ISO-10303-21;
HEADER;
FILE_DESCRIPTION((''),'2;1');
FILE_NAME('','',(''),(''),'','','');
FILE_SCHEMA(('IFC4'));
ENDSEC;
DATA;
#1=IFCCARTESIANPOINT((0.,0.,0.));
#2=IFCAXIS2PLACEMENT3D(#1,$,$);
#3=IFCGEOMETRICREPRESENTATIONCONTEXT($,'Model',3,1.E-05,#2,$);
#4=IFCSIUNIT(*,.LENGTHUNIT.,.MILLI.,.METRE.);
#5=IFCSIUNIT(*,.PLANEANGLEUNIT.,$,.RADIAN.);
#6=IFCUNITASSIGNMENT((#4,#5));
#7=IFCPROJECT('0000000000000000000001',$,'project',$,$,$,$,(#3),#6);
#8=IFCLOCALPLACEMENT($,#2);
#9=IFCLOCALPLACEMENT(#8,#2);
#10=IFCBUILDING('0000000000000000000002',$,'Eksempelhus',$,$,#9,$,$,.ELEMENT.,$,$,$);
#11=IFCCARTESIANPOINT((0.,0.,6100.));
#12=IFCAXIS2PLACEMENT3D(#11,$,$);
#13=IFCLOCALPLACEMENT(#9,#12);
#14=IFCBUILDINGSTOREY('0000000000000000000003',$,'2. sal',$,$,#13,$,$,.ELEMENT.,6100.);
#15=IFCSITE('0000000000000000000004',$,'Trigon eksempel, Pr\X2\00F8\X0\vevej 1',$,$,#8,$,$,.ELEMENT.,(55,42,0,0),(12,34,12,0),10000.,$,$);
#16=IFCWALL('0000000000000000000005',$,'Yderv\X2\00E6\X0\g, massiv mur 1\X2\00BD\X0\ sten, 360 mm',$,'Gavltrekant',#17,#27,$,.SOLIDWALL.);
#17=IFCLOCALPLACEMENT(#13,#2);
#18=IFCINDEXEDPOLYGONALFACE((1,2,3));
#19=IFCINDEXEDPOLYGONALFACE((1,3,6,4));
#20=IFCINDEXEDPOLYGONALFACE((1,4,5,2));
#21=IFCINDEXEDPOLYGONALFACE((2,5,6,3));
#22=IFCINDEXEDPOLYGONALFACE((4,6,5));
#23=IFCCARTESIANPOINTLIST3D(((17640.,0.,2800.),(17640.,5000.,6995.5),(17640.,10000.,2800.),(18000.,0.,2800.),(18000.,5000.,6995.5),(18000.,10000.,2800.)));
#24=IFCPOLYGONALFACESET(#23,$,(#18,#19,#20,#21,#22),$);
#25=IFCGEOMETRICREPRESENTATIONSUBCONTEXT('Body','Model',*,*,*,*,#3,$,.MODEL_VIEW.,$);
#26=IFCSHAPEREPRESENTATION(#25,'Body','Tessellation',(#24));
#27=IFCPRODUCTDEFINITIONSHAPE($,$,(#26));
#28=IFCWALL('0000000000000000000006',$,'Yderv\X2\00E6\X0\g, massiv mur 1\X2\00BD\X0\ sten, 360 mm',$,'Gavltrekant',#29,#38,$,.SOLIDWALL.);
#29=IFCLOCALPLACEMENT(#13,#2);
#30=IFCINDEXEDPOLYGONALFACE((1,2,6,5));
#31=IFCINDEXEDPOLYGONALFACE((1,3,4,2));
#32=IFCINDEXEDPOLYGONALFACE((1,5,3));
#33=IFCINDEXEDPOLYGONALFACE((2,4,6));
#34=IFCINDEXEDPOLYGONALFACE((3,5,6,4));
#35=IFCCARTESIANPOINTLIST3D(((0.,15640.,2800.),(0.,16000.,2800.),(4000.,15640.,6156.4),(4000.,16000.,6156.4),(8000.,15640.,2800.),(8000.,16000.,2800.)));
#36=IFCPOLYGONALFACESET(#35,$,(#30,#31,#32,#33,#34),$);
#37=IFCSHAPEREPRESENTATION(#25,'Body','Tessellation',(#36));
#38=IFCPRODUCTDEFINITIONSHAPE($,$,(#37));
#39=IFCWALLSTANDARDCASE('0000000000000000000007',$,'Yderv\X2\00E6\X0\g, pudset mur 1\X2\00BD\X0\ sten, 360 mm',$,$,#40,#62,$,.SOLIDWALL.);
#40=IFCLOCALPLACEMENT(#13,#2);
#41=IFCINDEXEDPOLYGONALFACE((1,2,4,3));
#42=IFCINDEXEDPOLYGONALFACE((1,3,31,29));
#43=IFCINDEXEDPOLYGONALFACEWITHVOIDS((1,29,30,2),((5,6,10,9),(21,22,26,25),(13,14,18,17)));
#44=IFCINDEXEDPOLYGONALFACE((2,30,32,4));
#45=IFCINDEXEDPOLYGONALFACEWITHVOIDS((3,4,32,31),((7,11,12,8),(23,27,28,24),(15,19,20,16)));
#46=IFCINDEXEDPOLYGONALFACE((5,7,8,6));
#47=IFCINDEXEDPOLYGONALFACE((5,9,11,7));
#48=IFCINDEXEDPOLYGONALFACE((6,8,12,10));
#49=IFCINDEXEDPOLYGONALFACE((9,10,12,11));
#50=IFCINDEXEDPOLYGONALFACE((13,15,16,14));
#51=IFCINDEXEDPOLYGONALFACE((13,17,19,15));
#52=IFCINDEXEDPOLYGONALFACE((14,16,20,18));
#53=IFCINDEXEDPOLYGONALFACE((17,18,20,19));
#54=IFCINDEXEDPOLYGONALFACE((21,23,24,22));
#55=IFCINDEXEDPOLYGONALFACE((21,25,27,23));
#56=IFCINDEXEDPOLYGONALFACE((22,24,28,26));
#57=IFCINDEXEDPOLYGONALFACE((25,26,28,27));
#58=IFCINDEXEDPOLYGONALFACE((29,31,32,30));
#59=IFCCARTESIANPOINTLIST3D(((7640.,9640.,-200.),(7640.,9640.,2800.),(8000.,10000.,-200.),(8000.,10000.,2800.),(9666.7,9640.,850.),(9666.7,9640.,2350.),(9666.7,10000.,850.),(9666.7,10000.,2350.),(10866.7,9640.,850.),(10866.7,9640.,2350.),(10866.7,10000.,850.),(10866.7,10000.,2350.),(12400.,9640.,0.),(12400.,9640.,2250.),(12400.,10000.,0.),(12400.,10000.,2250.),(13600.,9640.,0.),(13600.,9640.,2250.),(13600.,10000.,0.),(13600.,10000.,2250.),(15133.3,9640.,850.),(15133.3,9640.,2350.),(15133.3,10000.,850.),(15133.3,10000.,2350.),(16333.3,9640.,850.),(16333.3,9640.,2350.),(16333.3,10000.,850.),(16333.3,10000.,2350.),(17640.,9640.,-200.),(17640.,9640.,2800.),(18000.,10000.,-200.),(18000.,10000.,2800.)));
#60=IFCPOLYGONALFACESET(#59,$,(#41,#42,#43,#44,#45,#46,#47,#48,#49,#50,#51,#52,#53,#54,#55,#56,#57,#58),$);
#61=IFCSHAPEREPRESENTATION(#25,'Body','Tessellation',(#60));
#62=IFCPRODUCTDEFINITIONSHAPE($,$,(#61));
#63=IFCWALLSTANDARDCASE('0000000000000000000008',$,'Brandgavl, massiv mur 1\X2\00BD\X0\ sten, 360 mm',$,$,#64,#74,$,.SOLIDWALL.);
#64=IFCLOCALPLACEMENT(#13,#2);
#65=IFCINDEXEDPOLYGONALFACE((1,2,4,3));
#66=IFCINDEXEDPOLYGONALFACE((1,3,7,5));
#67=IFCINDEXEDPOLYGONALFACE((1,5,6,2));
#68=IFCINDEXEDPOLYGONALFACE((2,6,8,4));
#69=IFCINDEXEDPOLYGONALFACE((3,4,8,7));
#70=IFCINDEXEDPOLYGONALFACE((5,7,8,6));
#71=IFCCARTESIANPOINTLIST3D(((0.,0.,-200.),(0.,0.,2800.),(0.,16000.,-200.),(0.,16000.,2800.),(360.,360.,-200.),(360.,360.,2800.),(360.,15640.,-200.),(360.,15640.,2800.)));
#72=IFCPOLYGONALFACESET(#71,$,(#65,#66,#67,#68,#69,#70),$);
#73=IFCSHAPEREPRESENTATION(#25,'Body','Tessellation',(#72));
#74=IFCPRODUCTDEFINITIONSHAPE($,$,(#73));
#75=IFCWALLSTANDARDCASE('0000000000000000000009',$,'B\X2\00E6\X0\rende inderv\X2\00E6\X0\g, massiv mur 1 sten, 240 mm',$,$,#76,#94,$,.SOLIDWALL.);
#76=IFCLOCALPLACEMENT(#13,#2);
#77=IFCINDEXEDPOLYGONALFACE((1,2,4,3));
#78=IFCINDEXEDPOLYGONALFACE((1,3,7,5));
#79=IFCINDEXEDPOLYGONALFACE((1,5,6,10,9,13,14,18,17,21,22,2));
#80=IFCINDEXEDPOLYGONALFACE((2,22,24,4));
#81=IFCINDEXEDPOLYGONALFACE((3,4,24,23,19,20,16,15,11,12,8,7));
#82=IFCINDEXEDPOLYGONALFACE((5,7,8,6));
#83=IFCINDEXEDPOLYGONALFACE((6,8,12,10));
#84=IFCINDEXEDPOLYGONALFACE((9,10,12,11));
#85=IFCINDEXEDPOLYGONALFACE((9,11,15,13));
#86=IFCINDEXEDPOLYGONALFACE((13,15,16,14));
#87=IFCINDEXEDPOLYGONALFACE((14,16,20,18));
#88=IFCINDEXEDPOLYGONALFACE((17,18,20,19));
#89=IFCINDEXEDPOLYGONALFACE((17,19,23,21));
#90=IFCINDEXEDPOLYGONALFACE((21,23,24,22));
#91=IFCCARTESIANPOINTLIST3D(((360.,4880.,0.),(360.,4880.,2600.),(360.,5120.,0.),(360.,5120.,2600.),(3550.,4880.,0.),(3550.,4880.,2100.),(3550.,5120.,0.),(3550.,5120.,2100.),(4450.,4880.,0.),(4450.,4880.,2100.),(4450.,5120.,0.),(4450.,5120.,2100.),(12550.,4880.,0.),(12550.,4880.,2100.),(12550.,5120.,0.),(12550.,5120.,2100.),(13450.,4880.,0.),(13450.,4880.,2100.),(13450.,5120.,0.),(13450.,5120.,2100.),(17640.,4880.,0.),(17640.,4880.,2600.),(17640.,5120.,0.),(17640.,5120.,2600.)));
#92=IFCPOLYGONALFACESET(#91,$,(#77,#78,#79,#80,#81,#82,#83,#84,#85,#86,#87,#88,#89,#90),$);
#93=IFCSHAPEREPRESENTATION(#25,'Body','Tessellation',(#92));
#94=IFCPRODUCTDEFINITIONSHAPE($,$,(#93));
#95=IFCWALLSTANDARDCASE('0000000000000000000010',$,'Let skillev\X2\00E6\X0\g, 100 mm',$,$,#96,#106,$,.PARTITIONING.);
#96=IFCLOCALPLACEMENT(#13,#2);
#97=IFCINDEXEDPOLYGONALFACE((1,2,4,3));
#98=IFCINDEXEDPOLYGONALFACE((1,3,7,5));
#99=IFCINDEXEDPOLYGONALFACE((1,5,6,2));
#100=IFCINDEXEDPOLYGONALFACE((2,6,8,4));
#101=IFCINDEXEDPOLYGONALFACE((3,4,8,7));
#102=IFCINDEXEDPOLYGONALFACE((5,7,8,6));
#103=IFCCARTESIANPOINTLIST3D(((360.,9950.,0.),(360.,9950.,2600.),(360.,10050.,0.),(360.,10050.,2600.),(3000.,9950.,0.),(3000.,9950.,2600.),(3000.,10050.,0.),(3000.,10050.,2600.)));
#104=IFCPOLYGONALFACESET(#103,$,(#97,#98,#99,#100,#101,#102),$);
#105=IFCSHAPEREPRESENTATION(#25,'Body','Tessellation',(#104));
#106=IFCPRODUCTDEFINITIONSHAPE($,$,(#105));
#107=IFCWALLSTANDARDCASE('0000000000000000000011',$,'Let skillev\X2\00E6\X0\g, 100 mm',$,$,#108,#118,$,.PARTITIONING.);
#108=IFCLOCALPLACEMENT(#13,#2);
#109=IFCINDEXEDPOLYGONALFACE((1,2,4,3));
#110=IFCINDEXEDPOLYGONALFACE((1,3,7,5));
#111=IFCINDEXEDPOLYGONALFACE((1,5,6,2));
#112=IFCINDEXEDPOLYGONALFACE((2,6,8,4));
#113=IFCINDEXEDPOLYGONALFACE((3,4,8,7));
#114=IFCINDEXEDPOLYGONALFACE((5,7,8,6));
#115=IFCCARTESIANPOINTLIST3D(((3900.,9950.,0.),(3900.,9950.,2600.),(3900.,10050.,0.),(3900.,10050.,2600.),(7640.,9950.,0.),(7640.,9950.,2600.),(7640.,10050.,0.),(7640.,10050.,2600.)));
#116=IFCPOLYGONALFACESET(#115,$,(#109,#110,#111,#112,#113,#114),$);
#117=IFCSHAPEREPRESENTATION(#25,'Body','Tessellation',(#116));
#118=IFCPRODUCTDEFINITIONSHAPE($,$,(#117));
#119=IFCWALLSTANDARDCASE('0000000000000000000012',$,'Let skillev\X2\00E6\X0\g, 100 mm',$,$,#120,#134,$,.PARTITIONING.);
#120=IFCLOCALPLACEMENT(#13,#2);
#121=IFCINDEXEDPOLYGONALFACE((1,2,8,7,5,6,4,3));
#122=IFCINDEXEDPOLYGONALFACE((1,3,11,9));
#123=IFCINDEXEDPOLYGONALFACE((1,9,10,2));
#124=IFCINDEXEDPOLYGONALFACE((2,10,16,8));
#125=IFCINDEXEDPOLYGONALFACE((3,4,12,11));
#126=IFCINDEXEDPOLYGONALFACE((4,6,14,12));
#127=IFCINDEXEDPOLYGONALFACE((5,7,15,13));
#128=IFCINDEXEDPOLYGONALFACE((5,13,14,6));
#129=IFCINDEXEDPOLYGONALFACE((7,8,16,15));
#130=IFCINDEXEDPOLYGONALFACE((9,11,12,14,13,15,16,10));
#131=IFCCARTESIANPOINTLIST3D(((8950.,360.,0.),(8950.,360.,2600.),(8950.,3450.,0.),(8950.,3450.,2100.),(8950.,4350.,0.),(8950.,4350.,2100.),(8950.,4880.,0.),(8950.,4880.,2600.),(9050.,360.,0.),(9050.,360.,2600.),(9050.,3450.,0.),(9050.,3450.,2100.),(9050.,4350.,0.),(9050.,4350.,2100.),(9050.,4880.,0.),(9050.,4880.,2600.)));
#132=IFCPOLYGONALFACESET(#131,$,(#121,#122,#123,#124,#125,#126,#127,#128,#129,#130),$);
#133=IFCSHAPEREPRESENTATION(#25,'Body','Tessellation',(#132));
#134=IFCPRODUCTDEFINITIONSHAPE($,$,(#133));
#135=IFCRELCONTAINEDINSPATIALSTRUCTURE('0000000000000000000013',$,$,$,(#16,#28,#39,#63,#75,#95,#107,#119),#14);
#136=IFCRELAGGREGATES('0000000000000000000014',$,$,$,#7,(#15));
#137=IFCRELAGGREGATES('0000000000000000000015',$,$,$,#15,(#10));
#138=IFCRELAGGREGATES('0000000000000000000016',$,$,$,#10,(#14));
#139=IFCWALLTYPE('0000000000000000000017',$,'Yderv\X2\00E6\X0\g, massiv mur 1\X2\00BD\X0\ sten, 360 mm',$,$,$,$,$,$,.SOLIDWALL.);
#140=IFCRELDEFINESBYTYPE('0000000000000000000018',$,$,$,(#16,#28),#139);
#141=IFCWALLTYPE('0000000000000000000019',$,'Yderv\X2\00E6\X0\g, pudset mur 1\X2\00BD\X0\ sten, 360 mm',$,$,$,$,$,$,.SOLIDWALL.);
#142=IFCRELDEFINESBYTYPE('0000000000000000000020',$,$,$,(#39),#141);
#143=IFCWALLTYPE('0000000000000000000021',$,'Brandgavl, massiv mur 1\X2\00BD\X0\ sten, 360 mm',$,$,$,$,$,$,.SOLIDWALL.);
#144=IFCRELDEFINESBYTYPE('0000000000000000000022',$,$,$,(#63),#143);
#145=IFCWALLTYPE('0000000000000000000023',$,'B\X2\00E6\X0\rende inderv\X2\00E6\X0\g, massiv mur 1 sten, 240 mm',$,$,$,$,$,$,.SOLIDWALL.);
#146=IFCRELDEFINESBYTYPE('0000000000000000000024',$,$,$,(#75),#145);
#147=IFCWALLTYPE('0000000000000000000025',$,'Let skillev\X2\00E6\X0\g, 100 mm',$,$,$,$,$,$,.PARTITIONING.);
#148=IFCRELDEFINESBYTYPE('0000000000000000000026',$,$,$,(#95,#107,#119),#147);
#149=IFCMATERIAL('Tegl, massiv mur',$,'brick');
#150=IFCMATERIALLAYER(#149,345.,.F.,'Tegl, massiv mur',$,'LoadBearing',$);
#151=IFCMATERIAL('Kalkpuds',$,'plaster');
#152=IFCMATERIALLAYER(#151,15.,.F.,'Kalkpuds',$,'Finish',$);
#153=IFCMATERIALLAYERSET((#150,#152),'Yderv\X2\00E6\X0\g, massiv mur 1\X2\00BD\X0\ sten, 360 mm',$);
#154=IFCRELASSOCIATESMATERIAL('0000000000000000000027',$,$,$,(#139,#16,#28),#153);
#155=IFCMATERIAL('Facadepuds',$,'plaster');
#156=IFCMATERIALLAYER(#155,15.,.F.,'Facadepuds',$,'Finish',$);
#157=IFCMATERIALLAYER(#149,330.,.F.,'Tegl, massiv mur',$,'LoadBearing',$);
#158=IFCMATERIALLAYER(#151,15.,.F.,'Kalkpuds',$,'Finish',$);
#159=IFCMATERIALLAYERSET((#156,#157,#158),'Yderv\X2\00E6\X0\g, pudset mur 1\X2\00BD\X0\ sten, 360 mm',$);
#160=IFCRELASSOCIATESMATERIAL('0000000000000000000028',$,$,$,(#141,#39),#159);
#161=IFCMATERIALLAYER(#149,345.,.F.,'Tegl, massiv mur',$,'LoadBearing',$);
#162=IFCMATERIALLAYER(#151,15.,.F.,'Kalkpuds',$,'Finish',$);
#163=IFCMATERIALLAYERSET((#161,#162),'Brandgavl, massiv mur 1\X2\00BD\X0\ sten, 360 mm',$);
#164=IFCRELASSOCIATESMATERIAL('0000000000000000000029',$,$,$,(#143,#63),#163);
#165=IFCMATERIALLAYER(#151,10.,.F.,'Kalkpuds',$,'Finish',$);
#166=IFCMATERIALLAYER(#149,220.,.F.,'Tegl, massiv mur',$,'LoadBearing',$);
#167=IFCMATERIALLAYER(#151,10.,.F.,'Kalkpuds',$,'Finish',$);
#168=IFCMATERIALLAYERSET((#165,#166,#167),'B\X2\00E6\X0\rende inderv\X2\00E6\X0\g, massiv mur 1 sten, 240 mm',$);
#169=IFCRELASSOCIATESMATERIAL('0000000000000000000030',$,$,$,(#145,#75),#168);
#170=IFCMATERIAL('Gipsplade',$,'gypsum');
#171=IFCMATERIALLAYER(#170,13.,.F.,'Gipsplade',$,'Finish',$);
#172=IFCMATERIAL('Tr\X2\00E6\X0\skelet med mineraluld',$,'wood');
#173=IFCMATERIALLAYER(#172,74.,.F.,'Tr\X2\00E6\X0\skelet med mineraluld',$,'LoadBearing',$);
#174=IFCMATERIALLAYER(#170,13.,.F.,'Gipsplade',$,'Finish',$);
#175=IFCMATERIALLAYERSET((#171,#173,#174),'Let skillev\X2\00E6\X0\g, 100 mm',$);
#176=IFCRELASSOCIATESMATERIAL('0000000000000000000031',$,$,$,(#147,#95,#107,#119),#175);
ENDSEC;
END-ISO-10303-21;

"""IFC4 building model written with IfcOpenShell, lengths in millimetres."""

from ifc_helpers import new_model, si_unit, frame, origin, place, context, subcontext, project, spatial, polyline, rectangle, outline, extrude, material, layer, layer_set, layer_usage, type_object, element, save


model = new_model("IFC4")

# Units and contexts
model_context = context("Model", 3, precision=1e-05, world=origin())
body_context = subcontext(model_context, "Body", "Model", "MODEL_VIEW")
ifc_project = project(units=[si_unit("LENGTHUNIT", "METRE", prefix="MILLI"), si_unit("PLANEANGLEUNIT", "RADIAN")], contexts=[model_context])

# Site, building, storey
site_placement = place(None, origin())
site = spatial("IfcSite", under=ifc_project, at=site_placement, Name="Trigon eksempel, Prøvevej 1", CompositionType="ELEMENT", RefLatitude=(55, 42, 0, 0), RefLongitude=(12, 34, 12, 0), RefElevation=10000.0)
building_placement = place(site_placement, origin())
building = spatial("IfcBuilding", under=site, at=building_placement, Name="Eksempelhus", CompositionType="ELEMENT")
storey_placement = place(building_placement, frame((0.0, 0.0, 6100.0)))
storey = spatial("IfcBuildingStorey", under=building, at=storey_placement, Name="2. sal", CompositionType="ELEMENT", Elevation=6100.0)

# Shared definitions
ifc_material_1 = material(Name="Tegl, massiv mur", Category="brick")
ifc_layer_1 = layer(ifc_material_1, 345.0, ventilated=False, Name="Tegl, massiv mur", Category="LoadBearing")
ifc_material_2 = material(Name="Kalkpuds", Category="plaster")
ifc_layer_2 = layer(ifc_material_2, 15.0, ventilated=False, Name="Kalkpuds", Category="Finish")
ifc_layer_set_1 = layer_set([ifc_layer_1, ifc_layer_2], Name="Ydervæg, massiv mur 1½ sten, 360 mm")
wall_type_1 = type_object("IfcWallType", Name="Ydervæg, massiv mur 1½ sten, 360 mm", PredefinedType="SOLIDWALL", material=ifc_layer_set_1)

# Walls
wall_1_placement = place(storey_placement, frame((18000.0, 0.0, 2800.0), z_axis=(0.0, 0.0, 1.0), x_axis=(0.0, 1.0, 0.0)))
element("IfcWall", 1, at=wall_1_placement, inside=storey, type_object=wall_type_1, material=ifc_layer_set_1, Name="Ydervæg, massiv mur 1½ sten, 360 mm", ObjectType="Gavltrekant", PredefinedType="SOLIDWALL", context=body_context, shape_type="SweptSolid", body=[
    extrude(outline(polyline([(10000.0, 0.0), (0.0, 0.0), (5000.0, -4195.5), (10000.0, 0.0)])), frame((0.0, 0.0, 0.0), z_axis=(0.0, 1.0, 0.0), x_axis=(1.0, 0.0, 0.0)), (0.0, 0.0, 1.0), 360.0),
])
wall_2_placement = place(storey_placement, frame((8000.0, 16000.0, 2800.0), z_axis=(0.0, 0.0, 1.0), x_axis=(-1.0, 0.0, 0.0)))
element("IfcWall", 2, at=wall_2_placement, inside=storey, type_object=wall_type_1, material=ifc_layer_set_1, Name="Ydervæg, massiv mur 1½ sten, 360 mm", ObjectType="Gavltrekant", PredefinedType="SOLIDWALL", context=body_context, shape_type="SweptSolid", body=[
    extrude(outline(polyline([(8000.0, 0.0), (0.0, 0.0), (4000.0, -3356.4), (8000.0, 0.0)])), frame((0.0, 0.0, 0.0), z_axis=(0.0, 1.0, 0.0), x_axis=(1.0, 0.0, 0.0)), (0.0, 0.0, 1.0), 360.0),
])

# Wall, openings
ifc_material_3 = material(Name="Facadepuds", Category="plaster")
ifc_layer_3 = layer(ifc_material_3, 15.0, ventilated=False, Name="Facadepuds", Category="Finish")
ifc_layer_4 = layer(ifc_material_1, 330.0, ventilated=False, Name="Tegl, massiv mur", Category="LoadBearing")
ifc_layer_5 = layer(ifc_material_2, 15.0, ventilated=False, Name="Kalkpuds", Category="Finish")
ifc_layer_set_2 = layer_set([ifc_layer_3, ifc_layer_4, ifc_layer_5], Name="Ydervæg, pudset mur 1½ sten, 360 mm")
ifc_layer_usage_1 = layer_usage(ifc_layer_set_2, "AXIS2", "POSITIVE", 0.0)
wall_type_2 = type_object("IfcWallType", Name="Ydervæg, pudset mur 1½ sten, 360 mm", PredefinedType="SOLIDWALL", material=ifc_layer_set_2)
wall_3_placement = place(storey_placement, frame((18000.0, 10000.0, -200.0), z_axis=(0.0, 0.0, 1.0), x_axis=(-1.0, 0.0, 0.0)))
wall_3 = element("IfcWallStandardCase", 3, at=wall_3_placement, inside=storey, type_object=wall_type_2, material=ifc_layer_usage_1, Name="Ydervæg, pudset mur 1½ sten, 360 mm", PredefinedType="SOLIDWALL", context=body_context, shape_type="SweptSolid", body=[
    extrude(outline(polyline([(0.0, 0.0), (10000.0, 0.0), (10360.0, 360.0), (360.0, 360.0), (0.0, 0.0)])), origin(), (0.0, 0.0, 1.0), 3000.0),
])
opening_1_placement = place(wall_3_placement, frame((1666.7, 0.0, 1050.0)))
element("IfcOpeningElement", 4, at=opening_1_placement, cuts=wall_3, PredefinedType="OPENING", context=body_context, shape_type="SweptSolid", body=[
    extrude(rectangle(XDim=1200.0, YDim=1500.0), frame((600.0, 0.0, 750.0), z_axis=(0.0, 1.0, 0.0), x_axis=(1.0, 0.0, 0.0)), (0.0, 0.0, 1.0), 360.0),
])
opening_2_placement = place(wall_3_placement, frame((4400.0, 0.0, 200.0)))
element("IfcOpeningElement", 5, at=opening_2_placement, cuts=wall_3, PredefinedType="OPENING", context=body_context, shape_type="SweptSolid", body=[
    extrude(rectangle(XDim=1200.0, YDim=2250.0), frame((600.0, 0.0, 1125.0), z_axis=(0.0, 1.0, 0.0), x_axis=(1.0, 0.0, 0.0)), (0.0, 0.0, 1.0), 360.0),
])
opening_3_placement = place(wall_3_placement, frame((7133.3, 0.0, 1050.0)))
element("IfcOpeningElement", 6, at=opening_3_placement, cuts=wall_3, PredefinedType="OPENING", context=body_context, shape_type="SweptSolid", body=[
    extrude(rectangle(XDim=1200.0, YDim=1500.0), frame((600.0, 0.0, 750.0), z_axis=(0.0, 1.0, 0.0), x_axis=(1.0, 0.0, 0.0)), (0.0, 0.0, 1.0), 360.0),
])

# Wall
ifc_layer_6 = layer(ifc_material_1, 345.0, ventilated=False, Name="Tegl, massiv mur", Category="LoadBearing")
ifc_layer_7 = layer(ifc_material_2, 15.0, ventilated=False, Name="Kalkpuds", Category="Finish")
ifc_layer_set_3 = layer_set([ifc_layer_6, ifc_layer_7], Name="Brandgavl, massiv mur 1½ sten, 360 mm")
ifc_layer_usage_2 = layer_usage(ifc_layer_set_3, "AXIS2", "POSITIVE", 0.0)
wall_type_3 = type_object("IfcWallType", Name="Brandgavl, massiv mur 1½ sten, 360 mm", PredefinedType="SOLIDWALL", material=ifc_layer_set_3)
wall_4_placement = place(storey_placement, frame((0.0, 16000.0, -200.0), z_axis=(0.0, 0.0, 1.0), x_axis=(0.0, -1.0, 0.0)))
element("IfcWallStandardCase", 7, at=wall_4_placement, inside=storey, type_object=wall_type_3, material=ifc_layer_usage_2, Name="Brandgavl, massiv mur 1½ sten, 360 mm", PredefinedType="SOLIDWALL", context=body_context, shape_type="SweptSolid", body=[
    extrude(outline(polyline([(0.0, 0.0), (16000.0, 0.0), (15640.0, 360.0), (360.0, 360.0), (0.0, 0.0)])), origin(), (0.0, 0.0, 1.0), 3000.0),
])

# Wall, openings
ifc_layer_8 = layer(ifc_material_2, 10.0, ventilated=False, Name="Kalkpuds", Category="Finish")
ifc_layer_9 = layer(ifc_material_1, 220.0, ventilated=False, Name="Tegl, massiv mur", Category="LoadBearing")
ifc_layer_10 = layer(ifc_material_2, 10.0, ventilated=False, Name="Kalkpuds", Category="Finish")
ifc_layer_set_4 = layer_set([ifc_layer_8, ifc_layer_9, ifc_layer_10], Name="Bærende indervæg, massiv mur 1 sten, 240 mm")
ifc_layer_usage_3 = layer_usage(ifc_layer_set_4, "AXIS2", "POSITIVE", -120.0)
wall_type_4 = type_object("IfcWallType", Name="Bærende indervæg, massiv mur 1 sten, 240 mm", PredefinedType="SOLIDWALL", material=ifc_layer_set_4)
wall_5_placement = place(storey_placement, frame((360.0, 5000.0, 0.0)))
wall_5 = element("IfcWallStandardCase", 8, at=wall_5_placement, inside=storey, type_object=wall_type_4, material=ifc_layer_usage_3, Name="Bærende indervæg, massiv mur 1 sten, 240 mm", PredefinedType="SOLIDWALL", context=body_context, shape_type="SweptSolid", body=[
    extrude(outline(polyline([(0.0, -120.0), (17280.0, -120.0), (17280.0, 120.0), (0.0, 120.0), (0.0, -120.0)])), origin(), (0.0, 0.0, 1.0), 2600.0),
])
opening_4_placement = place(wall_5_placement, frame((3190.0, -120.0, 0.0)))
element("IfcOpeningElement", 9, at=opening_4_placement, cuts=wall_5, PredefinedType="OPENING", context=body_context, shape_type="SweptSolid", body=[
    extrude(rectangle(XDim=900.0, YDim=2100.0), frame((450.0, 0.0, 1050.0), z_axis=(0.0, 1.0, 0.0), x_axis=(1.0, 0.0, 0.0)), (0.0, 0.0, 1.0), 240.0),
])
opening_5_placement = place(wall_5_placement, frame((12190.0, -120.0, 0.0)))
element("IfcOpeningElement", 10, at=opening_5_placement, cuts=wall_5, PredefinedType="OPENING", context=body_context, shape_type="SweptSolid", body=[
    extrude(rectangle(XDim=900.0, YDim=2100.0), frame((450.0, 0.0, 1050.0), z_axis=(0.0, 1.0, 0.0), x_axis=(1.0, 0.0, 0.0)), (0.0, 0.0, 1.0), 240.0),
])

# Walls
ifc_material_4 = material(Name="Gipsplade", Category="gypsum")
ifc_layer_11 = layer(ifc_material_4, 13.0, ventilated=False, Name="Gipsplade", Category="Finish")
ifc_material_5 = material(Name="Træskelet med mineraluld", Category="wood")
ifc_layer_12 = layer(ifc_material_5, 74.0, ventilated=False, Name="Træskelet med mineraluld", Category="LoadBearing")
ifc_layer_13 = layer(ifc_material_4, 13.0, ventilated=False, Name="Gipsplade", Category="Finish")
ifc_layer_set_5 = layer_set([ifc_layer_11, ifc_layer_12, ifc_layer_13], Name="Let skillevæg, 100 mm")
ifc_layer_usage_4 = layer_usage(ifc_layer_set_5, "AXIS2", "POSITIVE", -50.0)
wall_type_5 = type_object("IfcWallType", Name="Let skillevæg, 100 mm", PredefinedType="PARTITIONING", material=ifc_layer_set_5)
wall_6_placement = place(storey_placement, frame((360.0, 10000.0, 0.0)))
element("IfcWallStandardCase", 11, at=wall_6_placement, inside=storey, type_object=wall_type_5, material=ifc_layer_usage_4, Name="Let skillevæg, 100 mm", PredefinedType="PARTITIONING", context=body_context, shape_type="SweptSolid", body=[
    extrude(outline(polyline([(0.0, -50.0), (2640.0, -50.0), (2640.0, 50.0), (0.0, 50.0), (0.0, -50.0)])), origin(), (0.0, 0.0, 1.0), 2600.0),
])
wall_7_placement = place(storey_placement, frame((3900.0, 10000.0, 0.0)))
element("IfcWallStandardCase", 12, at=wall_7_placement, inside=storey, type_object=wall_type_5, material=ifc_layer_usage_4, Name="Let skillevæg, 100 mm", PredefinedType="PARTITIONING", context=body_context, shape_type="SweptSolid", body=[
    extrude(outline(polyline([(0.0, -50.0), (3740.0, -50.0), (3740.0, 50.0), (0.0, 50.0), (0.0, -50.0)])), origin(), (0.0, 0.0, 1.0), 2600.0),
])

# Wall, opening
wall_8_placement = place(storey_placement, frame((9000.0, 360.0, 0.0), z_axis=(0.0, 0.0, 1.0), x_axis=(0.0, 1.0, 0.0)))
wall_8 = element("IfcWallStandardCase", 13, at=wall_8_placement, inside=storey, type_object=wall_type_5, material=ifc_layer_usage_4, Name="Let skillevæg, 100 mm", PredefinedType="PARTITIONING", context=body_context, shape_type="SweptSolid", body=[
    extrude(outline(polyline([(0.0, -50.0), (4520.0, -50.0), (4520.0, 50.0), (0.0, 50.0), (0.0, -50.0)])), origin(), (0.0, 0.0, 1.0), 2600.0),
])
opening_6_placement = place(wall_8_placement, frame((3090.0, -50.0, 0.0)))
element("IfcOpeningElement", 14, at=opening_6_placement, cuts=wall_8, PredefinedType="OPENING", context=body_context, shape_type="SweptSolid", body=[
    extrude(rectangle(XDim=900.0, YDim=2100.0), frame((450.0, 0.0, 1050.0), z_axis=(0.0, 1.0, 0.0), x_axis=(1.0, 0.0, 0.0)), (0.0, 0.0, 1.0), 100.0),
])

save(model, "model.ifc")
